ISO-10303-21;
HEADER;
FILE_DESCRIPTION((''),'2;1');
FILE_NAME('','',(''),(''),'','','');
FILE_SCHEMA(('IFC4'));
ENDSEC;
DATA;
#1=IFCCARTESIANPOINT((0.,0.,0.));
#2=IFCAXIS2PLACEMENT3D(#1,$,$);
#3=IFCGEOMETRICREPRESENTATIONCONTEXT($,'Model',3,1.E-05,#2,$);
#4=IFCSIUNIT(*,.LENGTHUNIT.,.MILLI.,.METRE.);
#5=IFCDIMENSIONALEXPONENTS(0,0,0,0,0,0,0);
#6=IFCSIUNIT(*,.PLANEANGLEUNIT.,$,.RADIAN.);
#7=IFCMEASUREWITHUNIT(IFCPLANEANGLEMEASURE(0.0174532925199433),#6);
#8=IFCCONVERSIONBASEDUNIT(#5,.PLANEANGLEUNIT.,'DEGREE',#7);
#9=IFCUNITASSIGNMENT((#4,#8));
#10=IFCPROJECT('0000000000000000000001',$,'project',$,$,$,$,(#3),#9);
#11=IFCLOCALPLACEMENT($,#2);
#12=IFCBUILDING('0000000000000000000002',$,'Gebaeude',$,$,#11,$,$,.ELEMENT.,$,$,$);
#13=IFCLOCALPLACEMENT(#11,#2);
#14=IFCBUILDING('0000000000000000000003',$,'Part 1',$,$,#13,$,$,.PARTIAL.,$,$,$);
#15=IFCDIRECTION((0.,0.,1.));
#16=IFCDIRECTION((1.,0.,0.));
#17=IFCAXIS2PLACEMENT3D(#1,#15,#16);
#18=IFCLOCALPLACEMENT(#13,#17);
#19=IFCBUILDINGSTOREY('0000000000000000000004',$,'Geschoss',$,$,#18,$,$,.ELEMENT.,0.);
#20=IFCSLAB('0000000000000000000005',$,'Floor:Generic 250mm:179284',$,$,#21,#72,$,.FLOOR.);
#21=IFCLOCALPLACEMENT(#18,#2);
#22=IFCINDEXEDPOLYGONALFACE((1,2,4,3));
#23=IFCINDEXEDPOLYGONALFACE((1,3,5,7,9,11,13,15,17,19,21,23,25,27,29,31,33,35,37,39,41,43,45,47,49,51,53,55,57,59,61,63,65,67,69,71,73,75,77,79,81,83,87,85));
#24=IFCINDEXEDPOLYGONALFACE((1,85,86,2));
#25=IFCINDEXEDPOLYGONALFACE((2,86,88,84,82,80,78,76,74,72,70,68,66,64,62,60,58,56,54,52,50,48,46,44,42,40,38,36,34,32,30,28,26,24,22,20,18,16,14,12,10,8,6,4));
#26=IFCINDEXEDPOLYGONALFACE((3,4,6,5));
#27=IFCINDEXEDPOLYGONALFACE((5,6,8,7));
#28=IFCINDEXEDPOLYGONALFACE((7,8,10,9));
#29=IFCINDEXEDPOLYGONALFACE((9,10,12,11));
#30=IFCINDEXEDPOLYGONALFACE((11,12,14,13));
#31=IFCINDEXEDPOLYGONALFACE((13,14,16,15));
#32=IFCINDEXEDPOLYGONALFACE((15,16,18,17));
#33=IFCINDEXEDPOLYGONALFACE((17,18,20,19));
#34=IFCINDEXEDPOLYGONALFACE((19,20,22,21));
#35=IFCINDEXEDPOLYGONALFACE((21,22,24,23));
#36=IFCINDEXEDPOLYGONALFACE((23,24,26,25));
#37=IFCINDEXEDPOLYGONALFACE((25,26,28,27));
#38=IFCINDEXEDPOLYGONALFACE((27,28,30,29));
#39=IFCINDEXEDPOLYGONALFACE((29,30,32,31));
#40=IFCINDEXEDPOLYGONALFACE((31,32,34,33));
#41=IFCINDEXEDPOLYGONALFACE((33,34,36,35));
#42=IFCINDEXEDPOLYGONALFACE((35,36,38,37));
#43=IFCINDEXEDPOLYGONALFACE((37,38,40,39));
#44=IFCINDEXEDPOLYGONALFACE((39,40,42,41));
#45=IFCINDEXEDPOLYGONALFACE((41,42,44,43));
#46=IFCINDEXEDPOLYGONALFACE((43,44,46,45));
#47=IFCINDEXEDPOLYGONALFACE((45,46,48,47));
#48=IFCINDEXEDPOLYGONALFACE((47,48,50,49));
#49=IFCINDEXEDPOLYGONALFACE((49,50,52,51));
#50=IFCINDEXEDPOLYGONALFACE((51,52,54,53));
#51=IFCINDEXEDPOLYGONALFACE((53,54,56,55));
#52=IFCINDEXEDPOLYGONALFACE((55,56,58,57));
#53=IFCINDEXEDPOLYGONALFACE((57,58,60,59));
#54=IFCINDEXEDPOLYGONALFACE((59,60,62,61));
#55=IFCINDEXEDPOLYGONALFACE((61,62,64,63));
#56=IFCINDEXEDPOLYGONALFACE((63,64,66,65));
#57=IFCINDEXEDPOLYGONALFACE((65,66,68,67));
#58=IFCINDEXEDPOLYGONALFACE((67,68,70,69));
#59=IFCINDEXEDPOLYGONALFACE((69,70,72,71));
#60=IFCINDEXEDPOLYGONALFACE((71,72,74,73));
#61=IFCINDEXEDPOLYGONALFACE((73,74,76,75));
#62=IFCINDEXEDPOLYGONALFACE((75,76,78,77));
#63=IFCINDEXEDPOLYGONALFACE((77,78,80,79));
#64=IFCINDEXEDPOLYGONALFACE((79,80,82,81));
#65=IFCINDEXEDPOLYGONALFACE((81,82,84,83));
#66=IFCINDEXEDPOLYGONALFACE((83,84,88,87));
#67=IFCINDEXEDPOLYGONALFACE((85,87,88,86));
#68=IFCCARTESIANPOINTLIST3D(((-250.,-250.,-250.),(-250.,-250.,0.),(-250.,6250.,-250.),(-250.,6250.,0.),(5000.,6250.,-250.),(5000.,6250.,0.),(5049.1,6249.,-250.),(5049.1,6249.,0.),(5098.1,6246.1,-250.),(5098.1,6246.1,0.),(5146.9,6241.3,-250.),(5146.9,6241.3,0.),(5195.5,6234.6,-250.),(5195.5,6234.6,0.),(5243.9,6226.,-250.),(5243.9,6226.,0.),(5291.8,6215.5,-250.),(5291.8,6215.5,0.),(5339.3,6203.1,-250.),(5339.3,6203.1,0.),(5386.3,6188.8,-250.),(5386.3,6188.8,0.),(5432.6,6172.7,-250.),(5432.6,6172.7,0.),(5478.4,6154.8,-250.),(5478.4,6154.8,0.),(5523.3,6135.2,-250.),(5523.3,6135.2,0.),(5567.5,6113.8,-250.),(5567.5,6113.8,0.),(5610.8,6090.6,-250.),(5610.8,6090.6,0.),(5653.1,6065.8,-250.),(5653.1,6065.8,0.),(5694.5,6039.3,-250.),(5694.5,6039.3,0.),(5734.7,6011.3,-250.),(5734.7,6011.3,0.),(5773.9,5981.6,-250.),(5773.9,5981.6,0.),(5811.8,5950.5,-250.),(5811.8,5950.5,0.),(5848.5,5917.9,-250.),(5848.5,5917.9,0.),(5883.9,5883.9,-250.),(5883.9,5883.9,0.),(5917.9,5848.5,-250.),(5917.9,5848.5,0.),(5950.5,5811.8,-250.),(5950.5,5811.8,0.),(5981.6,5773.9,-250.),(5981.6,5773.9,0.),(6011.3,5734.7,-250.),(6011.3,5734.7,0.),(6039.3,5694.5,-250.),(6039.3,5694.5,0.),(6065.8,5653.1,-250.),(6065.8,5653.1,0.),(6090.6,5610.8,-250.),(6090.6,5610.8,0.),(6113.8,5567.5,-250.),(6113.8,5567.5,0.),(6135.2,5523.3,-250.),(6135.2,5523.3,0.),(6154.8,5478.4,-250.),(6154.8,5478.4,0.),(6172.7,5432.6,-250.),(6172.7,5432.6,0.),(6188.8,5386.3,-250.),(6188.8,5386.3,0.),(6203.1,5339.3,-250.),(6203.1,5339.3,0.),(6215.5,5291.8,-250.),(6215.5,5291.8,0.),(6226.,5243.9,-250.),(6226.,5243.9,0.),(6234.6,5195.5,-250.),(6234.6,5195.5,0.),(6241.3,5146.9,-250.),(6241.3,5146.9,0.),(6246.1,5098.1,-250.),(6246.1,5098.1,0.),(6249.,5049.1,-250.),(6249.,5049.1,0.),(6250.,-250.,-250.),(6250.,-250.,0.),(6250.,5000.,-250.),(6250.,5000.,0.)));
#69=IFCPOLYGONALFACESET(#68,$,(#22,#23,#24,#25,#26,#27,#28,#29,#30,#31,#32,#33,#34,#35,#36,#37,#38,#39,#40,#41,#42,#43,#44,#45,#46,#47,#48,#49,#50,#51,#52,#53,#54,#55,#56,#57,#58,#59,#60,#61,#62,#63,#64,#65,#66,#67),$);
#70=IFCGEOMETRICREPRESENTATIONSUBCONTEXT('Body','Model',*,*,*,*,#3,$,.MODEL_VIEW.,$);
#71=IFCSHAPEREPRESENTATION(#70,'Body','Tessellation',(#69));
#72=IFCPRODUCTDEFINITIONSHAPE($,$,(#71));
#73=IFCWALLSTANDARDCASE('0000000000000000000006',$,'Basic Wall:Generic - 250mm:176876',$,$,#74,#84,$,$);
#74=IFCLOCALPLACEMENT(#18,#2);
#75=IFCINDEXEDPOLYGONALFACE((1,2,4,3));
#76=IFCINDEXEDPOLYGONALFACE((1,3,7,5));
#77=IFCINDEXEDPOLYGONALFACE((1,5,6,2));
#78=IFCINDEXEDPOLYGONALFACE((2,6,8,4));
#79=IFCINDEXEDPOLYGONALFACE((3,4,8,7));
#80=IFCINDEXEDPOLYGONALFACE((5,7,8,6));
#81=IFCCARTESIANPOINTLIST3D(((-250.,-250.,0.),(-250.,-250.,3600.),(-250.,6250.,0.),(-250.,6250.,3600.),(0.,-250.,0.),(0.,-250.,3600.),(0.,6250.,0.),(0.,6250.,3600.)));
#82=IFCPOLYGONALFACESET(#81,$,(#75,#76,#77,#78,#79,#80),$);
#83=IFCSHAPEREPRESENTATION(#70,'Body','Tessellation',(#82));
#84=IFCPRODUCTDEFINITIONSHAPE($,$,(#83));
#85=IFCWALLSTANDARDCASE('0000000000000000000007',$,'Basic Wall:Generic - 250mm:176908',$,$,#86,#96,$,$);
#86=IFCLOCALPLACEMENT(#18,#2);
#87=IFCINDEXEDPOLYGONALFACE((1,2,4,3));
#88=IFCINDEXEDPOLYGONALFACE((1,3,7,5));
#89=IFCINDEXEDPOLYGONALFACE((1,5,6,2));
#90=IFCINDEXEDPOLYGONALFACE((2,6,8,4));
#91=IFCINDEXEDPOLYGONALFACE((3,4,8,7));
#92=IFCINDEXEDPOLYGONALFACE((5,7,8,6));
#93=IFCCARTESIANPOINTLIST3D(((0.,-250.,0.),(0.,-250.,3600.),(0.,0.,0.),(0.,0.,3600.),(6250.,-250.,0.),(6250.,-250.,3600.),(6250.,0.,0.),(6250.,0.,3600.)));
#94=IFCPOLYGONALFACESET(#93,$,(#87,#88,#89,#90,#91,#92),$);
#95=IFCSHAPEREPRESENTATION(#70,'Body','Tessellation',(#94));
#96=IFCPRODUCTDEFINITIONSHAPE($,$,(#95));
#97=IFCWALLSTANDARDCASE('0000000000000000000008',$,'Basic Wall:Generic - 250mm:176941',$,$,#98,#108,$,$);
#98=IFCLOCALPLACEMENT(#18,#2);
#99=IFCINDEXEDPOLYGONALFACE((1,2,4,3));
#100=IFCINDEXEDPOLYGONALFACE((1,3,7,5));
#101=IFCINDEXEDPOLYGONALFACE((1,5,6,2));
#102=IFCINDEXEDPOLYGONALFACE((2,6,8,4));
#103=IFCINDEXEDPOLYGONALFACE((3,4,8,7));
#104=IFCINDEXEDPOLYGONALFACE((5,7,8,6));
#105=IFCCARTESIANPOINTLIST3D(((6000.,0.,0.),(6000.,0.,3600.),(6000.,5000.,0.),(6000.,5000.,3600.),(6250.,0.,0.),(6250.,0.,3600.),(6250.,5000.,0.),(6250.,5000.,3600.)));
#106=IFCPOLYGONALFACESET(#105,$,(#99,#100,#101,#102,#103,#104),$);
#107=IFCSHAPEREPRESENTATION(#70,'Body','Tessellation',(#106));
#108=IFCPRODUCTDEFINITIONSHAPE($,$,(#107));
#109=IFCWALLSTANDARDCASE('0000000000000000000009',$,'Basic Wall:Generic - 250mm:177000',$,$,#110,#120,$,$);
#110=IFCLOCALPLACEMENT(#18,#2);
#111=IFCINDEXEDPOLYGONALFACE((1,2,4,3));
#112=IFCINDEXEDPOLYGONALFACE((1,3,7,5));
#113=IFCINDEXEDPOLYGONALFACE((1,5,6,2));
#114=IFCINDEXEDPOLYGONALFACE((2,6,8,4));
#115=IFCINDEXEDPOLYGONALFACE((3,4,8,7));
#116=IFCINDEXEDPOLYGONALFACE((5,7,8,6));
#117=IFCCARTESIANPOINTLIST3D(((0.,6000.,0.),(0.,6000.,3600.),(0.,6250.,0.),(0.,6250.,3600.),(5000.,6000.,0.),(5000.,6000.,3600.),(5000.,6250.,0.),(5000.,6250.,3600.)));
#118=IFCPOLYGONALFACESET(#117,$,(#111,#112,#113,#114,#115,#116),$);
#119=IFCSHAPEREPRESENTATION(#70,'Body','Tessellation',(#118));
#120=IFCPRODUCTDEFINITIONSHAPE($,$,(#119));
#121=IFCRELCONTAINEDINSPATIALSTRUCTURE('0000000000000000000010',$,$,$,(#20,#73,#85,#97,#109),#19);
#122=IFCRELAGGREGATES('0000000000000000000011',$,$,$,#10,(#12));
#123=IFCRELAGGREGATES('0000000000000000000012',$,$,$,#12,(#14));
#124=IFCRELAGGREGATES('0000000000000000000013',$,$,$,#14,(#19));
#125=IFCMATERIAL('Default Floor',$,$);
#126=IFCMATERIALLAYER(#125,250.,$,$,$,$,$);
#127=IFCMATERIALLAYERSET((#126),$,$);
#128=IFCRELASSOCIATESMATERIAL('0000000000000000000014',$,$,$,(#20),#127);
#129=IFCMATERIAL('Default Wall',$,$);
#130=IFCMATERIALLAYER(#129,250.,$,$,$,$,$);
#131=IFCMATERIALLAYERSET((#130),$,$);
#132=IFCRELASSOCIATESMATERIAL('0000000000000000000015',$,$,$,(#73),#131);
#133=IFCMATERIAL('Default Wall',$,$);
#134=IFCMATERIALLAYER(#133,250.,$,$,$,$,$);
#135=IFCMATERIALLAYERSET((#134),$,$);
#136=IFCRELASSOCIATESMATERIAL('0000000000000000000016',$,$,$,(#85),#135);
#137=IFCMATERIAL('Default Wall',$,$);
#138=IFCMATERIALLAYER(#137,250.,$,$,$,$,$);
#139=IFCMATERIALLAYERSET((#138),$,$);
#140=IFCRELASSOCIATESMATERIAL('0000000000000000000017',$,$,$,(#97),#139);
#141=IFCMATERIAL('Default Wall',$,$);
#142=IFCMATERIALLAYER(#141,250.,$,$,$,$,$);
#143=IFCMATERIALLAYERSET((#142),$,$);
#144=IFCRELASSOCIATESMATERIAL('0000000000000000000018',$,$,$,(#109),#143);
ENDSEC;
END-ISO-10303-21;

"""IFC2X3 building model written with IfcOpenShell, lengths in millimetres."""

from ifc_helpers import new_model, entity, si_unit, converted_unit, frame, frame_2d, origin, origin_with_axes, place, context, subcontext, project, spatial, polyline, rectangle, outline, extrude, material, layer, layer_set, layer_usage, element, save


model = new_model("IFC2X3")

# Units and contexts
model_context = context("Model", 3, precision=1e-05, world=origin())
body_context = subcontext(model_context, "Body", "Model", "MODEL_VIEW")
ifc_project = project(units=[si_unit("LENGTHUNIT", "METRE", prefix="MILLI"), converted_unit("PLANEANGLEUNIT", "DEGREE", entity("IfcPlaneAngleMeasure", 0.0174532925199433), si_unit("PLANEANGLEUNIT", "RADIAN"), dimensions=[0, 0, 0, 0, 0, 0, 0])], contexts=[model_context])

# Buildings, storey
building_1_placement = place(None, origin())
building_1 = spatial("IfcBuilding", under=ifc_project, at=building_1_placement, Name="Gebaeude", CompositionType="ELEMENT")
building_2_placement = place(building_1_placement, origin())
building_2 = spatial("IfcBuilding", under=building_1, at=building_2_placement, Name="Part 1", CompositionType="PARTIAL")
storey_placement = place(building_2_placement, origin_with_axes())
storey = spatial("IfcBuildingStorey", under=building_2, at=storey_placement, Name="Geschoss", CompositionType="ELEMENT", Elevation=0.0)

# Slab
ifc_material_1 = material(Name="Default Floor")
ifc_layer_1 = layer(ifc_material_1, 250.0)
ifc_layer_set_1 = layer_set([ifc_layer_1])
ifc_layer_usage_1 = layer_usage(ifc_layer_set_1, "AXIS3", "POSITIVE", 0.0)
slab_placement = place(storey_placement, frame((-250.0, -250.0, -250.0), z_axis=(0.0, 0.0, 1.0), x_axis=(1.0, 0.0, 0.0)))
element("IfcSlab", 1, at=slab_placement, inside=storey, material=ifc_layer_usage_1, Name="Floor:Generic 250mm:179284", PredefinedType="FLOOR", context=body_context, shape_type="SweptSolid", body=[
    extrude(outline(polyline([(0.0, 6500.0), (0.0, 0.0), (6500.0, 0.0), (6500.0, 5250.0), (6499.0, 5299.1), (6496.1, 5348.1), (6491.3, 5396.9), (6484.6, 5445.5), (6476.0, 5493.9), (6465.5, 5541.8), (6453.1, 5589.3), (6438.8, 5636.3), (6422.7, 5682.6), (6404.8, 5728.4), (6385.2, 5773.3), (6363.8, 5817.5), (6340.6, 5860.8), (6315.8, 5903.1), (6289.3, 5944.5), (6261.3, 5984.7), (6231.6, 6023.9), (6200.5, 6061.8), (6167.9, 6098.5), (6133.9, 6133.9), (6098.5, 6167.9), (6061.8, 6200.5), (6023.9, 6231.6), (5984.7, 6261.3), (5944.5, 6289.3), (5903.1, 6315.8), (5860.8, 6340.6), (5817.5, 6363.8), (5773.3, 6385.2), (5728.4, 6404.8), (5682.6, 6422.7), (5636.3, 6438.8), (5589.3, 6453.1), (5541.8, 6465.5), (5493.9, 6476.0), (5445.5, 6484.6), (5396.9, 6491.3), (5348.1, 6496.1), (5299.1, 6499.0), (5250.0, 6500.0), (0.0, 6500.0)])), origin_with_axes(), (0.0, 0.0, 1.0), 250.0),
])

# Walls
ifc_material_2 = material(Name="Default Wall")
ifc_layer_2 = layer(ifc_material_2, 250.0)
ifc_layer_set_2 = layer_set([ifc_layer_2])
ifc_layer_usage_2 = layer_usage(ifc_layer_set_2, "AXIS2", "POSITIVE", -125.0)
wall_1_placement = place(storey_placement, frame((-250.0, 6250.0, 0.0), z_axis=(0.0, 0.0, 1.0), x_axis=(0.0, -1.0, 0.0)))
element("IfcWallStandardCase", 2, at=wall_1_placement, inside=storey, material=ifc_layer_usage_2, Name="Basic Wall:Generic - 250mm:176876", context=body_context, shape_type="SweptSolid", body=[
    extrude(rectangle(XDim=6500.0, YDim=250.0, at=frame_2d((3250.0, 125.0), x_axis=(1.0, 0.0))), origin_with_axes(), (0.0, 0.0, 1.0), 3600.0),
])
ifc_material_3 = material(Name="Default Wall")
ifc_layer_3 = layer(ifc_material_3, 250.0)
ifc_layer_set_3 = layer_set([ifc_layer_3])
ifc_layer_usage_3 = layer_usage(ifc_layer_set_3, "AXIS2", "POSITIVE", -125.0)
wall_2_placement = place(storey_placement, frame((0.0, -250.0, 0.0), z_axis=(0.0, 0.0, 1.0), x_axis=(1.0, 0.0, 0.0)))
element("IfcWallStandardCase", 3, at=wall_2_placement, inside=storey, material=ifc_layer_usage_3, Name="Basic Wall:Generic - 250mm:176908", context=body_context, shape_type="SweptSolid", body=[
    extrude(rectangle(XDim=6250.0, YDim=250.0, at=frame_2d((3125.0, 125.0), x_axis=(1.0, 0.0))), origin_with_axes(), (0.0, 0.0, 1.0), 3600.0),
])
ifc_material_4 = material(Name="Default Wall")
ifc_layer_4 = layer(ifc_material_4, 250.0)
ifc_layer_set_4 = layer_set([ifc_layer_4])
ifc_layer_usage_4 = layer_usage(ifc_layer_set_4, "AXIS2", "POSITIVE", -125.0)
wall_3_placement = place(storey_placement, frame((6250.0, 0.0, 0.0), z_axis=(0.0, 0.0, 1.0), x_axis=(0.0, 1.0, 0.0)))
element("IfcWallStandardCase", 4, at=wall_3_placement, inside=storey, material=ifc_layer_usage_4, Name="Basic Wall:Generic - 250mm:176941", context=body_context, shape_type="SweptSolid", body=[
    extrude(rectangle(XDim=5000.0, YDim=250.0, at=frame_2d((2500.0, 125.0), x_axis=(1.0, 0.0))), origin_with_axes(), (0.0, 0.0, 1.0), 3600.0),
])
ifc_material_5 = material(Name="Default Wall")
ifc_layer_5 = layer(ifc_material_5, 250.0)
ifc_layer_set_5 = layer_set([ifc_layer_5])
ifc_layer_usage_5 = layer_usage(ifc_layer_set_5, "AXIS2", "POSITIVE", -125.0)
wall_4_placement = place(storey_placement, frame((0.0, 6000.0, 0.0), z_axis=(0.0, 0.0, 1.0), x_axis=(1.0, 0.0, 0.0)))
element("IfcWallStandardCase", 5, at=wall_4_placement, inside=storey, material=ifc_layer_usage_5, Name="Basic Wall:Generic - 250mm:177000", context=body_context, shape_type="SweptSolid", body=[
    extrude(rectangle(XDim=5000.0, YDim=250.0, at=frame_2d((2500.0, 125.0), x_axis=(1.0, 0.0))), origin_with_axes(), (0.0, 0.0, 1.0), 3600.0),
])

save(model, "model.ifc")
